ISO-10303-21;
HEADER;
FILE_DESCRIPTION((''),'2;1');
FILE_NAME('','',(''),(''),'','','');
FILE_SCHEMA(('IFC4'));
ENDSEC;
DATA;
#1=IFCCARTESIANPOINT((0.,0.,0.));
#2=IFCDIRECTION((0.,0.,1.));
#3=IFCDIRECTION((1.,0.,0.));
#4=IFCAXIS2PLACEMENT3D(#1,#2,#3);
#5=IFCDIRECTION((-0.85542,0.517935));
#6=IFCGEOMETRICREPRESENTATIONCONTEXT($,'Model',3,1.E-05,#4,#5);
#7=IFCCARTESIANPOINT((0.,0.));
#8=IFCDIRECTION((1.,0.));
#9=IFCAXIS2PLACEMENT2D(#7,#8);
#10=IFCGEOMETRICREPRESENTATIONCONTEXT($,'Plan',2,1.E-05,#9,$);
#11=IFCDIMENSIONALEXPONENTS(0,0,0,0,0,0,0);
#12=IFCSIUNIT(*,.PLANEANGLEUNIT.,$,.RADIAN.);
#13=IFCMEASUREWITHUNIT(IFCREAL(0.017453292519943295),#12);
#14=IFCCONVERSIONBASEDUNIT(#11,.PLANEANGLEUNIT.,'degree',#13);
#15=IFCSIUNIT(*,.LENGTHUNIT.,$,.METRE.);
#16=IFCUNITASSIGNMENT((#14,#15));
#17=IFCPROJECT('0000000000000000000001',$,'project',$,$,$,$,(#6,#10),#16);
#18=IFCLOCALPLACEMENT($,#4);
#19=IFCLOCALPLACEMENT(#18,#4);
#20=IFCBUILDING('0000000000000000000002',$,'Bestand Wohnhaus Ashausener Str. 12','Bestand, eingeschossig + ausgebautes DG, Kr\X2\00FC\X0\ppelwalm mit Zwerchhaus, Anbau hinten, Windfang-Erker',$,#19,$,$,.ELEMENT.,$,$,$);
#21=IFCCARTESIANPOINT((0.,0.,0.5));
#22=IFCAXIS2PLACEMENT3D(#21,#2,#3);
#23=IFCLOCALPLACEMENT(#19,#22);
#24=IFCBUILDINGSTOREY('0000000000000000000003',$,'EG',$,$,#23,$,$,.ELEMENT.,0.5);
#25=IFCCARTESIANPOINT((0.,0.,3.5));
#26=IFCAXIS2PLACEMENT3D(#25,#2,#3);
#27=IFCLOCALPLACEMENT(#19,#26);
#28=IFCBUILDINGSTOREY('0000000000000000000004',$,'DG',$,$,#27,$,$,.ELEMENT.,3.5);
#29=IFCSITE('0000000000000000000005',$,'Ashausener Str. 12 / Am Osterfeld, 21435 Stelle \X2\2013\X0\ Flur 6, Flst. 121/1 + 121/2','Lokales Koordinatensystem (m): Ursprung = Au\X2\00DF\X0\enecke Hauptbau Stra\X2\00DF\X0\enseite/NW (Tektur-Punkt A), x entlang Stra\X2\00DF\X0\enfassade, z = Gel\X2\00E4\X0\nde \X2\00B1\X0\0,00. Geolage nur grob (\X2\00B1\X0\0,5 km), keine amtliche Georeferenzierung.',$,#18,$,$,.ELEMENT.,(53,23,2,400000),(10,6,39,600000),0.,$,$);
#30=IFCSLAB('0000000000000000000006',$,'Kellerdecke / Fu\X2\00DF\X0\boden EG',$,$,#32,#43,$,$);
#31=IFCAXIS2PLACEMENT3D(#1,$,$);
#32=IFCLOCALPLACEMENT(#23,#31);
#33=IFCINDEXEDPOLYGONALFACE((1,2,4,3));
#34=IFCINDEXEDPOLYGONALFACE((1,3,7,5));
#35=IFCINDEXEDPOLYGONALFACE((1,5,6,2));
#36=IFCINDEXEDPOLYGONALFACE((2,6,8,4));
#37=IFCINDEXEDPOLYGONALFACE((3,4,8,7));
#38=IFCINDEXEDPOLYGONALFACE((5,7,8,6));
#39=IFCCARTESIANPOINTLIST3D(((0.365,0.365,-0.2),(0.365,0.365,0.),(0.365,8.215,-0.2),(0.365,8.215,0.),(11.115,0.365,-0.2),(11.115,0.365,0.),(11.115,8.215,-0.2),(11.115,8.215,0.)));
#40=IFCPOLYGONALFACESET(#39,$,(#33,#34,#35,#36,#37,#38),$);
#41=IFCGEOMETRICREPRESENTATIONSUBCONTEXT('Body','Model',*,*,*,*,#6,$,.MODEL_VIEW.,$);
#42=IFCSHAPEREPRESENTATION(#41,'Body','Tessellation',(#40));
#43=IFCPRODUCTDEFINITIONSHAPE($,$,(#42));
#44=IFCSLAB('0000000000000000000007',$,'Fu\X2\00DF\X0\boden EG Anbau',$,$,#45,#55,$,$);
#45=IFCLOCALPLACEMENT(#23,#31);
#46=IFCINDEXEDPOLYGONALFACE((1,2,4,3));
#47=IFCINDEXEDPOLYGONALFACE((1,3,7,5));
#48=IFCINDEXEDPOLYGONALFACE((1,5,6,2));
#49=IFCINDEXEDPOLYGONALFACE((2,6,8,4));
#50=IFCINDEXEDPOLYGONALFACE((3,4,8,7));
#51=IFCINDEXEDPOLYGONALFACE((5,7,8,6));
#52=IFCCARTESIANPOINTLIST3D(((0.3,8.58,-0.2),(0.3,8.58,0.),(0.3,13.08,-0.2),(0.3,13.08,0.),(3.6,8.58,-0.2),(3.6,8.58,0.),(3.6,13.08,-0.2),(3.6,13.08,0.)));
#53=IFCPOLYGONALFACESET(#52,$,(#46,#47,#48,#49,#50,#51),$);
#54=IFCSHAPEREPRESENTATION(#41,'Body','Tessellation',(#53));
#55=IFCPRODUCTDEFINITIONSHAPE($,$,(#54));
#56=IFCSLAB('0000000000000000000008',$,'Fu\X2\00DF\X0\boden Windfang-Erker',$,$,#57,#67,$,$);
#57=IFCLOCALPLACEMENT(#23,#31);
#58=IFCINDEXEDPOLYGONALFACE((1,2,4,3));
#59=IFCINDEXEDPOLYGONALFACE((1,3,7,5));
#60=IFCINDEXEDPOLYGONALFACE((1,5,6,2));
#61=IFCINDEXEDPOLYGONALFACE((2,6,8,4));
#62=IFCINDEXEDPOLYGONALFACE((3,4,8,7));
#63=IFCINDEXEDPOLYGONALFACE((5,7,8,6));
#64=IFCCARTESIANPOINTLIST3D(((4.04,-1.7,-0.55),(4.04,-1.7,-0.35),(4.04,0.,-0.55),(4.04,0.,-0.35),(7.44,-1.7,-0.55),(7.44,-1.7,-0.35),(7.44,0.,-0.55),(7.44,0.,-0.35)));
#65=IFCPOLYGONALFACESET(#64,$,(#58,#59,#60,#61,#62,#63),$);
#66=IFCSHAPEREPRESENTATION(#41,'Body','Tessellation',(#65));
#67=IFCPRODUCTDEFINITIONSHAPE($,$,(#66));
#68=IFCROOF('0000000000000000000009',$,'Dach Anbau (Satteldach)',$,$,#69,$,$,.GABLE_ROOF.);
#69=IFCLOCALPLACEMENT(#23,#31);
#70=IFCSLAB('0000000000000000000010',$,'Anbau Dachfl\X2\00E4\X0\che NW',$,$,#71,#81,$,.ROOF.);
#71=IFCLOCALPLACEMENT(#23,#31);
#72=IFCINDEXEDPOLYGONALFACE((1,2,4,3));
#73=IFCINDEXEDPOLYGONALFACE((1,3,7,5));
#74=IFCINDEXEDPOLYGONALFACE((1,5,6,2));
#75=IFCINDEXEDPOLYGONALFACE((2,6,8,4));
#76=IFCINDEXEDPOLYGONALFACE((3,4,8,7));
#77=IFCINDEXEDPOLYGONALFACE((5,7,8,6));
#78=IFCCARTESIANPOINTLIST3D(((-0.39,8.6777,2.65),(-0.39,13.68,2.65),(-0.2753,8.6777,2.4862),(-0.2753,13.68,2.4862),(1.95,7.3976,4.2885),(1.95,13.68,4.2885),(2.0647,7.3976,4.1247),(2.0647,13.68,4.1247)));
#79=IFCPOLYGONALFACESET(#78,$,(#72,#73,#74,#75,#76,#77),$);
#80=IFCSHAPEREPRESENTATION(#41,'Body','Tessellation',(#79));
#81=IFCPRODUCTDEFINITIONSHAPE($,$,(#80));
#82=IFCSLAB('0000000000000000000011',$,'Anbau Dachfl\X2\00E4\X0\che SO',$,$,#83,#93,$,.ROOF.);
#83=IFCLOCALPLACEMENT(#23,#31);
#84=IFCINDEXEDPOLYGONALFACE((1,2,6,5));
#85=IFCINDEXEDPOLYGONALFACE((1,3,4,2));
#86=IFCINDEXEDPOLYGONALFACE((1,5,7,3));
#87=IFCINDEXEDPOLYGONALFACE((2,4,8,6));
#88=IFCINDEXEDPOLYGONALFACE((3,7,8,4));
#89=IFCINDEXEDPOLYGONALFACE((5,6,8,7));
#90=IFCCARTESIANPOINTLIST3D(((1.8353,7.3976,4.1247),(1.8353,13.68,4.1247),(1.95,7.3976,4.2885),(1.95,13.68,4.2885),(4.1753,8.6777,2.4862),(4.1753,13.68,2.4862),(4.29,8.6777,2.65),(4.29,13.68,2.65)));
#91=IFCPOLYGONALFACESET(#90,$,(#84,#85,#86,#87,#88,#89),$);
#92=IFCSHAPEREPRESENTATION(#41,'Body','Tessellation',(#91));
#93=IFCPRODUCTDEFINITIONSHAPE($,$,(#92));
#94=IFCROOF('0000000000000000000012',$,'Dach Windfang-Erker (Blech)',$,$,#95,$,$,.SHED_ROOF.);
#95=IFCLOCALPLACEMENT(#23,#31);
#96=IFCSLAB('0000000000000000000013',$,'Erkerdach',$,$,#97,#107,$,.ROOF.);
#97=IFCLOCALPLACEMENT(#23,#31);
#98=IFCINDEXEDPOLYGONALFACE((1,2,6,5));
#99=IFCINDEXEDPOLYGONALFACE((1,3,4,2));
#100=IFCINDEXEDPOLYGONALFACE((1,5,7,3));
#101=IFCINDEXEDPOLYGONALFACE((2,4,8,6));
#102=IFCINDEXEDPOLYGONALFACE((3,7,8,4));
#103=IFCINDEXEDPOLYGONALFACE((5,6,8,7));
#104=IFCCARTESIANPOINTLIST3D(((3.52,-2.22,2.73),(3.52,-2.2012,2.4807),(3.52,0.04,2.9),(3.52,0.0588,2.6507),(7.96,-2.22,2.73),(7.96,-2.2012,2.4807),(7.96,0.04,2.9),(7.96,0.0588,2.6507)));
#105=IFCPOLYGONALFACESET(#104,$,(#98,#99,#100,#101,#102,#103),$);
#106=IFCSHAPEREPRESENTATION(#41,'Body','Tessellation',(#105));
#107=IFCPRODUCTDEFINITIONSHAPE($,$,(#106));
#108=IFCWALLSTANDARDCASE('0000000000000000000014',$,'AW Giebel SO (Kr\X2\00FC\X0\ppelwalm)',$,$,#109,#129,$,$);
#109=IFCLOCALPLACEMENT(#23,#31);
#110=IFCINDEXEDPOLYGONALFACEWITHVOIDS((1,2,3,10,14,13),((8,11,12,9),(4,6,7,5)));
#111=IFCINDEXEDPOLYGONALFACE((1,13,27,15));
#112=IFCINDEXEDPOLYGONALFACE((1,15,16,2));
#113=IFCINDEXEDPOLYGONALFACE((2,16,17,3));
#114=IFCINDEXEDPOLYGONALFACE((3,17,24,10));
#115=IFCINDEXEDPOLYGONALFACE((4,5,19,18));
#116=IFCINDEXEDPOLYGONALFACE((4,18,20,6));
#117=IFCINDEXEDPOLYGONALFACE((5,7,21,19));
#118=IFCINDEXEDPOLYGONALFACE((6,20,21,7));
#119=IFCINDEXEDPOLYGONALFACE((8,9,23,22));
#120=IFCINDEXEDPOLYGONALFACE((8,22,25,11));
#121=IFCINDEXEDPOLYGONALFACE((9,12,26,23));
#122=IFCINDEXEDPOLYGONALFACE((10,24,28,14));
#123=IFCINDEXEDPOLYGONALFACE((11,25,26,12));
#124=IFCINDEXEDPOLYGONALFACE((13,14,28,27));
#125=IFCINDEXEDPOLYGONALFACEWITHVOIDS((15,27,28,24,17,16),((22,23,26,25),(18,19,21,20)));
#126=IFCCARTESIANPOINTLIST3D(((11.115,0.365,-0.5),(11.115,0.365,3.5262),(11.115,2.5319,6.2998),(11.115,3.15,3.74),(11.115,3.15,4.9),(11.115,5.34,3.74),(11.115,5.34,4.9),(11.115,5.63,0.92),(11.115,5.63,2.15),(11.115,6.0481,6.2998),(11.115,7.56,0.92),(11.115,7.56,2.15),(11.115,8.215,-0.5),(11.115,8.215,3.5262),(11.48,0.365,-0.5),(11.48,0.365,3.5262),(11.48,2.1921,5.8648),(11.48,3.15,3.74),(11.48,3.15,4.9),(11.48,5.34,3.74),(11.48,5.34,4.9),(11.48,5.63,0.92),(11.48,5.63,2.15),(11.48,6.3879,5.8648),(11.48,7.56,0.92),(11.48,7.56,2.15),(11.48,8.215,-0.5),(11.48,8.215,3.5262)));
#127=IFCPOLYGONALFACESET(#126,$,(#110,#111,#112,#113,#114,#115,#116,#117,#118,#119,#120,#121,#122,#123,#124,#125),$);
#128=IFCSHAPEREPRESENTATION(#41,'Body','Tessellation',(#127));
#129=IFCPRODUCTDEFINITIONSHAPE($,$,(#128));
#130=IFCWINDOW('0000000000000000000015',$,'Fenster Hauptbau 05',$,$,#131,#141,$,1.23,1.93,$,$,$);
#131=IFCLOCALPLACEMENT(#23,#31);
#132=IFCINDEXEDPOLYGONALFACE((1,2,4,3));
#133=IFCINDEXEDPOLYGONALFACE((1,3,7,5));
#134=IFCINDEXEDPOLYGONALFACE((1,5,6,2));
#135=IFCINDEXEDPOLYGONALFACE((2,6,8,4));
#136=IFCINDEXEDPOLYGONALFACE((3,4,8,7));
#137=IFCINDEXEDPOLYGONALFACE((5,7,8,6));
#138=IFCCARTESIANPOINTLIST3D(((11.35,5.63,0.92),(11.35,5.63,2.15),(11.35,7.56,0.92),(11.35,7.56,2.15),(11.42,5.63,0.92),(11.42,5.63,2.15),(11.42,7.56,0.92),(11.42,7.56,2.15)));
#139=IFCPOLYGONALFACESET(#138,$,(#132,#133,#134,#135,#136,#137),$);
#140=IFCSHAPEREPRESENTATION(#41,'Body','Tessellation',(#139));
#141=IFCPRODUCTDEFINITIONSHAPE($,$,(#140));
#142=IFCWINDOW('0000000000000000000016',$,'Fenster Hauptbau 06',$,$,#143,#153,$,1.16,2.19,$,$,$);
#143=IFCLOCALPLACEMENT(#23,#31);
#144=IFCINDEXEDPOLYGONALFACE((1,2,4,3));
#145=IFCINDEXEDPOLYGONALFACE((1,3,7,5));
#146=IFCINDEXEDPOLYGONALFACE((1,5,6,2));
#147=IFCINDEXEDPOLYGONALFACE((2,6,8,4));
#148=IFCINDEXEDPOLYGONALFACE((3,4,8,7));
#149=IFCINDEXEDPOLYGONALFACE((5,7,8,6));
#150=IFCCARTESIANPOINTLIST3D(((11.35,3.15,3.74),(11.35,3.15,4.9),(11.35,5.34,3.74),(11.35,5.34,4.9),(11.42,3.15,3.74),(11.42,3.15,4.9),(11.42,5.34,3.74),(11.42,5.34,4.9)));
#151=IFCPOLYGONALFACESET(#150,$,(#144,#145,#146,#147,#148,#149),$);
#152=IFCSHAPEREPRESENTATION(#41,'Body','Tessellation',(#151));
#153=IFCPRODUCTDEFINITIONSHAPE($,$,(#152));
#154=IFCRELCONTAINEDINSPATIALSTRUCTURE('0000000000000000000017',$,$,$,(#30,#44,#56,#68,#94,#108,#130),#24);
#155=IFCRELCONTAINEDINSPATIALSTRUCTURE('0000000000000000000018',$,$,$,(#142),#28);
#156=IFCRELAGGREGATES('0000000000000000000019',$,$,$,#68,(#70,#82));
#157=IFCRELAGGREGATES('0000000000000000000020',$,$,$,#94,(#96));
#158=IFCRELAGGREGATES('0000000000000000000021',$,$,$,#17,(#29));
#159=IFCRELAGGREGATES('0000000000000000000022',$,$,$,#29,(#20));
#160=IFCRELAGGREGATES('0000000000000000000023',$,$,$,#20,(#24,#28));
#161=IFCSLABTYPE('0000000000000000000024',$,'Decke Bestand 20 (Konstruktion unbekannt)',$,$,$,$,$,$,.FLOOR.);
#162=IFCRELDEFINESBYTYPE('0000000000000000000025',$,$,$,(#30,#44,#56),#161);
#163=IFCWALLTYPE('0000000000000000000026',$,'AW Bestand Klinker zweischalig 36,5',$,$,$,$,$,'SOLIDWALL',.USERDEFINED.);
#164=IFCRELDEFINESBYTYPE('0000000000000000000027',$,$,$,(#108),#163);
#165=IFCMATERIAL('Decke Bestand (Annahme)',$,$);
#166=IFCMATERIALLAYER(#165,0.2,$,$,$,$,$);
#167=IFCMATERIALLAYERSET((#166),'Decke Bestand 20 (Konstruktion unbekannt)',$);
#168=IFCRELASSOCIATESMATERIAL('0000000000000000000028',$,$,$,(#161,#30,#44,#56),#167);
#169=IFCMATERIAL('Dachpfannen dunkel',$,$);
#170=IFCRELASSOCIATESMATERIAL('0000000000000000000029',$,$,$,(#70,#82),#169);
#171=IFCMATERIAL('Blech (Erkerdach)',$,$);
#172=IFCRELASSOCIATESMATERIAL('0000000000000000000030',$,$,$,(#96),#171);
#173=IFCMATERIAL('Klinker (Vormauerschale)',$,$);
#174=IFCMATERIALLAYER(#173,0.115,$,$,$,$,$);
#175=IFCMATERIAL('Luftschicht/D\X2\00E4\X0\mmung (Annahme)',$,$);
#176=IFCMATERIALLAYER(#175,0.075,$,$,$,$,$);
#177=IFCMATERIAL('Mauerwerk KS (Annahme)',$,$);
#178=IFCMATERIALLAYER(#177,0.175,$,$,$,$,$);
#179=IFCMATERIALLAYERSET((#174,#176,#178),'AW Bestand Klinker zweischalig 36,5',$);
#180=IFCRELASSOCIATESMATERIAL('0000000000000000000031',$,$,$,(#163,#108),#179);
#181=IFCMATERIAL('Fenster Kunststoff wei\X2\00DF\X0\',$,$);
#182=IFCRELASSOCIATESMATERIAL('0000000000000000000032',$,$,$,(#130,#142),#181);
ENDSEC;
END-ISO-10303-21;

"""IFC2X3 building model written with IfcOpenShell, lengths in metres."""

from ifc_helpers import new_model, entity, si_unit, converted_unit, direction, frame, origin_with_axes, origin_2d_with_axis, place, context, subcontext, project, spatial, polyline, outline, extrude, clip, halfspace, material, layer, layer_set, layer_usage, type_object, element, fill, aggregate, save


model = new_model("IFC2X3")

# Units and contexts
model_context = context("Model", 3, precision=1e-05, world=origin_with_axes(), true_north=direction((-0.85542, 0.517935)))
plan_context = context("Plan", 2, precision=1e-05, world=origin_2d_with_axis())
body_context = subcontext(model_context, "Body", "Model", "MODEL_VIEW")
ifc_project = project(units=[converted_unit("PLANEANGLEUNIT", "degree", entity("IfcReal", 0.017453292519943295), si_unit("PLANEANGLEUNIT", "RADIAN"), dimensions=[0, 0, 0, 0, 0, 0, 0]), si_unit("LENGTHUNIT", "METRE")], contexts=[model_context, plan_context])

# Site, building, storey
site_placement = place(None, origin_with_axes())
site = spatial("IfcSite", under=ifc_project, at=site_placement, Name="Ashausener Str. 12 / Am Osterfeld, 21435 Stelle – Flur 6, Flst. 121/1 + 121/2", Description="Lokales Koordinatensystem (m): Ursprung = Außenecke Hauptbau Straßenseite/NW (Tektur-Punkt A), x entlang Straßenfassade, z = Gelände ±0,00. Geolage nur grob (±0,5 km), keine amtliche Georeferenzierung.", CompositionType="ELEMENT", RefLatitude=(53, 23, 2, 400000), RefLongitude=(10, 6, 39, 600000), RefElevation=0.0)
building_placement = place(site_placement, origin_with_axes())
building = spatial("IfcBuilding", under=site, at=building_placement, Name="Bestand Wohnhaus Ashausener Str. 12", Description="Bestand, eingeschossig + ausgebautes DG, Krüppelwalm mit Zwerchhaus, Anbau hinten, Windfang-Erker", CompositionType="ELEMENT")
storey_1_placement = place(building_placement, frame((0.0, 0.0, 0.5), z_axis=(0.0, 0.0, 1.0), x_axis=(1.0, 0.0, 0.0)))
storey_1 = spatial("IfcBuildingStorey", under=building, at=storey_1_placement, Name="EG", CompositionType="ELEMENT", Elevation=0.5)

# Slabs
ifc_material_1 = material(Name="Decke Bestand (Annahme)")
ifc_layer_1 = layer(ifc_material_1, 0.2)
ifc_layer_set_1 = layer_set([ifc_layer_1], Name="Decke Bestand 20 (Konstruktion unbekannt)")
ifc_layer_usage_1 = layer_usage(ifc_layer_set_1, "AXIS3", "POSITIVE", 0.0)
slab_type = type_object("IfcSlabType", Name="Decke Bestand 20 (Konstruktion unbekannt)", PredefinedType="FLOOR", material=ifc_layer_set_1)
slab_1_placement = place(storey_1_placement, frame((0.0, 0.0, -0.5), z_axis=(0.0, 0.0, 1.0), x_axis=(1.0, 0.0, 0.0)))
element("IfcSlab", 1, at=slab_1_placement, inside=storey_1, type_object=slab_type, material=ifc_layer_usage_1, Name="Kellerdecke / Fußboden EG", context=body_context, shape_type="SweptSolid", body=[
    extrude(outline(polyline([(0.365, 0.365), (11.115, 0.365), (11.115, 8.215), (0.365, 8.215), (0.365, 0.365)])), frame((0.0, 0.0, 0.3)), (0.0, 0.0, 1.0), 0.2),
])
ifc_layer_usage_2 = layer_usage(ifc_layer_set_1, "AXIS3", "POSITIVE", 0.0)
slab_2_placement = place(storey_1_placement, frame((0.0, 0.0, -0.5), z_axis=(0.0, 0.0, 1.0), x_axis=(1.0, 0.0, 0.0)))
element("IfcSlab", 2, at=slab_2_placement, inside=storey_1, type_object=slab_type, material=ifc_layer_usage_2, Name="Fußboden EG Anbau", context=body_context, shape_type="SweptSolid", body=[
    extrude(outline(polyline([(0.3, 8.58), (3.6, 8.58), (3.6, 13.08), (0.3, 13.08), (0.3, 8.58)])), frame((0.0, 0.0, 0.3)), (0.0, 0.0, 1.0), 0.2),
])
ifc_layer_usage_3 = layer_usage(ifc_layer_set_1, "AXIS3", "POSITIVE", 0.0)
slab_3_placement = place(storey_1_placement, frame((0.0, 0.0, -0.5), z_axis=(0.0, 0.0, 1.0), x_axis=(1.0, 0.0, 0.0)))
element("IfcSlab", 3, at=slab_3_placement, inside=storey_1, type_object=slab_type, material=ifc_layer_usage_3, Name="Fußboden Windfang-Erker", context=body_context, shape_type="SweptSolid", body=[
    extrude(outline(polyline([(4.04, -1.7), (7.44, -1.7), (7.44, 0.0), (4.04, 0.0), (4.04, -1.7)])), frame((0.0, 0.0, -0.05)), (0.0, 0.0, 1.0), 0.2),
])

# Roof, slabs
roof_1_placement = place(storey_1_placement, frame((0.0, 0.0, -0.5), z_axis=(0.0, 0.0, 1.0), x_axis=(1.0, 0.0, 0.0)))
roof_1 = element("IfcRoof", 4, at=roof_1_placement, inside=storey_1, Name="Dach Anbau (Satteldach)", ShapeType="GABLE_ROOF")
ifc_material_2 = material(Name="Dachpfannen dunkel")
slab_4_placement = place(roof_1_placement, origin_with_axes())
slab_4 = element("IfcSlab", 5, at=slab_4_placement, material=ifc_material_2, Name="Anbau Dachfläche NW", PredefinedType="ROOF", context=body_context, shape_type="SweptSolid", body=[
    extrude(outline(polyline([(0.0, 0.0), (2.8566, 0.0), (2.8566, -6.2824), (0.0, -5.0023), (0.0, 0.0)])), frame((-0.39, 13.68, 3.15), z_axis=(-0.573577, 0.0, 0.819151), x_axis=(0.819151, 0.0, 0.573577)), (0.0, 0.0, -1.0), 0.2),
])
slab_5_placement = place(roof_1_placement, origin_with_axes())
slab_5 = element("IfcSlab", 6, at=slab_5_placement, material=ifc_material_2, Name="Anbau Dachfläche SO", PredefinedType="ROOF", context=body_context, shape_type="SweptSolid", body=[
    extrude(outline(polyline([(0.0, 0.0), (2.8566, 0.0), (2.8566, -5.0023), (0.0, -6.2824), (0.0, 0.0)])), frame((1.95, 13.68, 4.7885), z_axis=(0.573577, 0.0, 0.819151), x_axis=(0.819151, 0.0, -0.573577)), (0.0, 0.0, -1.0), 0.2),
])
aggregate(roof_1, [slab_4, slab_5])

# Roof, slab
roof_2_placement = place(storey_1_placement, frame((0.0, 0.0, -0.5), z_axis=(0.0, 0.0, 1.0), x_axis=(1.0, 0.0, 0.0)))
roof_2 = element("IfcRoof", 7, at=roof_2_placement, inside=storey_1, Name="Dach Windfang-Erker (Blech)", ShapeType="SHED_ROOF")
ifc_material_3 = material(Name="Blech (Erkerdach)")
slab_6_placement = place(roof_2_placement, origin_with_axes())
slab_6 = element("IfcSlab", 8, at=slab_6_placement, material=ifc_material_3, Name="Erkerdach", PredefinedType="ROOF", context=body_context, shape_type="SweptSolid", body=[
    extrude(outline(polyline([(0.0, 0.0), (4.44, 0.0), (4.44, 2.2664), (0.0, 2.2664), (0.0, 0.0)])), frame((3.52, -2.22, 3.23), z_axis=(0.0, -0.075009, 0.997183), x_axis=(1.0, 0.0, 0.0)), (0.0, 0.0, -1.0), 0.25),
])
aggregate(roof_2, [slab_6])

# Shared definitions
ifc_material_4 = material(Name="Klinker (Vormauerschale)")
ifc_layer_2 = layer(ifc_material_4, 0.115)
ifc_material_5 = material(Name="Luftschicht/Dämmung (Annahme)")
ifc_layer_3 = layer(ifc_material_5, 0.075)
ifc_material_6 = material(Name="Mauerwerk KS (Annahme)")
ifc_layer_4 = layer(ifc_material_6, 0.175)
ifc_layer_set_2 = layer_set([ifc_layer_2, ifc_layer_3, ifc_layer_4], Name="AW Bestand Klinker zweischalig 36,5")
wall_type_1 = type_object("IfcWallType", Name="AW Bestand Klinker zweischalig 36,5", ElementType="SOLIDWALL", PredefinedType="USERDEFINED", material=ifc_layer_set_2)
ifc_material_7 = material(Name="Fenster Kunststoff weiß")

# Shared definitions
storey_2_placement = place(building_placement, frame((0.0, 0.0, 3.5), z_axis=(0.0, 0.0, 1.0), x_axis=(1.0, 0.0, 0.0)))
storey_2 = spatial("IfcBuildingStorey", under=building, at=storey_2_placement, Name="DG", CompositionType="ELEMENT", Elevation=3.5)

# Wall, openings, windows
ifc_layer_usage_4 = layer_usage(ifc_layer_set_2, "AXIS2", "POSITIVE", 0.0)
wall_1_placement = place(storey_1_placement, frame((11.48, 0.365, -0.5), z_axis=(0.0, 0.0, 1.0), x_axis=(0.0, 1.0, 0.0)))
wall_1 = element("IfcWallStandardCase", 9, at=wall_1_placement, inside=storey_1, type_object=wall_type_1, material=ifc_layer_usage_4, Name="AW Giebel SO (Krüppelwalm)", context=body_context, shape_type="Clipping", body=[
    clip(clip(clip(clip(extrude(outline(polyline([(0.0, 0.0), (0.0, 0.365), (7.85, 0.365), (7.85, 0.0), (0.0, 0.0)])), origin_with_axes(), (0.0, 0.0, 1.0), 12.0), halfspace(frame((-0.365, -0.39, 5.9), z_axis=(0.0, -0.76604, 0.64279), x_axis=(-1.0, 0.0, 0.0)), False)), halfspace(frame((-0.365, 11.87, 5.9), z_axis=(0.0, 0.76604, 0.64279), x_axis=(1.0, 0.0, 0.0)), False)), halfspace(frame((3.925, 11.48, 9.05), z_axis=(0.78801, 0.0, 0.61566), x_axis=(0.0, -1.0, 0.0)), False)), halfspace(frame((3.925, 11.48, 9.05), z_axis=(-0.78801, 0.0, 0.61566), x_axis=(0.0, 1.0, 0.0)), False)),
])
opening_1_placement = place(wall_1_placement, frame((5.265, -0.1, 1.42), z_axis=(0.0, 0.0, 1.0), x_axis=(1.0, 0.0, 0.0)))
opening_1 = element("IfcOpeningElement", 10, at=opening_1_placement, cuts=wall_1, context=body_context, shape_type="SweptSolid", body=[
    extrude(outline(polyline([(0.0, 0.0), (0.0, 0.565), (1.93, 0.565), (1.93, 0.0), (0.0, 0.0)])), origin_with_axes(), (0.0, 0.0, 1.0), 1.23),
])
opening_2_placement = place(wall_1_placement, frame((2.785, -0.1, 4.24), z_axis=(0.0, 0.0, 1.0), x_axis=(1.0, 0.0, 0.0)))
opening_2 = element("IfcOpeningElement", 11, at=opening_2_placement, cuts=wall_1, context=body_context, shape_type="SweptSolid", body=[
    extrude(outline(polyline([(0.0, 0.0), (0.0, 0.565), (2.19, 0.565), (2.19, 0.0), (0.0, 0.0)])), origin_with_axes(), (0.0, 0.0, 1.0), 1.16),
])
window_1_placement = place(storey_1_placement, frame((11.42, 5.63, 0.92), z_axis=(0.0, 0.0, 1.0), x_axis=(0.0, 1.0, 0.0)))
window_1 = element("IfcWindow", 12, at=window_1_placement, inside=storey_1, material=ifc_material_7, Name="Fenster Hauptbau 05", OverallHeight=1.23, OverallWidth=1.93, context=body_context, shape_type="SweptSolid", body=[
    extrude(outline(polyline([(0.0, 0.0), (0.0, 0.07), (1.93, 0.07), (1.93, 0.0), (0.0, 0.0)])), origin_with_axes(), (0.0, 0.0, 1.0), 1.23),
])
fill(opening_1, window_1)
window_2_placement = place(storey_2_placement, frame((11.42, 3.15, 0.74), z_axis=(0.0, 0.0, 1.0), x_axis=(0.0, 1.0, 0.0)))
window_2 = element("IfcWindow", 13, at=window_2_placement, inside=storey_2, material=ifc_material_7, Name="Fenster Hauptbau 06", OverallHeight=1.16, OverallWidth=2.19, context=body_context, shape_type="SweptSolid", body=[
    extrude(outline(polyline([(0.0, 0.0), (0.0, 0.07), (2.19, 0.07), (2.19, 0.0), (0.0, 0.0)])), origin_with_axes(), (0.0, 0.0, 1.0), 1.16),
])
fill(opening_2, window_2)

save(model, "model.ifc")
